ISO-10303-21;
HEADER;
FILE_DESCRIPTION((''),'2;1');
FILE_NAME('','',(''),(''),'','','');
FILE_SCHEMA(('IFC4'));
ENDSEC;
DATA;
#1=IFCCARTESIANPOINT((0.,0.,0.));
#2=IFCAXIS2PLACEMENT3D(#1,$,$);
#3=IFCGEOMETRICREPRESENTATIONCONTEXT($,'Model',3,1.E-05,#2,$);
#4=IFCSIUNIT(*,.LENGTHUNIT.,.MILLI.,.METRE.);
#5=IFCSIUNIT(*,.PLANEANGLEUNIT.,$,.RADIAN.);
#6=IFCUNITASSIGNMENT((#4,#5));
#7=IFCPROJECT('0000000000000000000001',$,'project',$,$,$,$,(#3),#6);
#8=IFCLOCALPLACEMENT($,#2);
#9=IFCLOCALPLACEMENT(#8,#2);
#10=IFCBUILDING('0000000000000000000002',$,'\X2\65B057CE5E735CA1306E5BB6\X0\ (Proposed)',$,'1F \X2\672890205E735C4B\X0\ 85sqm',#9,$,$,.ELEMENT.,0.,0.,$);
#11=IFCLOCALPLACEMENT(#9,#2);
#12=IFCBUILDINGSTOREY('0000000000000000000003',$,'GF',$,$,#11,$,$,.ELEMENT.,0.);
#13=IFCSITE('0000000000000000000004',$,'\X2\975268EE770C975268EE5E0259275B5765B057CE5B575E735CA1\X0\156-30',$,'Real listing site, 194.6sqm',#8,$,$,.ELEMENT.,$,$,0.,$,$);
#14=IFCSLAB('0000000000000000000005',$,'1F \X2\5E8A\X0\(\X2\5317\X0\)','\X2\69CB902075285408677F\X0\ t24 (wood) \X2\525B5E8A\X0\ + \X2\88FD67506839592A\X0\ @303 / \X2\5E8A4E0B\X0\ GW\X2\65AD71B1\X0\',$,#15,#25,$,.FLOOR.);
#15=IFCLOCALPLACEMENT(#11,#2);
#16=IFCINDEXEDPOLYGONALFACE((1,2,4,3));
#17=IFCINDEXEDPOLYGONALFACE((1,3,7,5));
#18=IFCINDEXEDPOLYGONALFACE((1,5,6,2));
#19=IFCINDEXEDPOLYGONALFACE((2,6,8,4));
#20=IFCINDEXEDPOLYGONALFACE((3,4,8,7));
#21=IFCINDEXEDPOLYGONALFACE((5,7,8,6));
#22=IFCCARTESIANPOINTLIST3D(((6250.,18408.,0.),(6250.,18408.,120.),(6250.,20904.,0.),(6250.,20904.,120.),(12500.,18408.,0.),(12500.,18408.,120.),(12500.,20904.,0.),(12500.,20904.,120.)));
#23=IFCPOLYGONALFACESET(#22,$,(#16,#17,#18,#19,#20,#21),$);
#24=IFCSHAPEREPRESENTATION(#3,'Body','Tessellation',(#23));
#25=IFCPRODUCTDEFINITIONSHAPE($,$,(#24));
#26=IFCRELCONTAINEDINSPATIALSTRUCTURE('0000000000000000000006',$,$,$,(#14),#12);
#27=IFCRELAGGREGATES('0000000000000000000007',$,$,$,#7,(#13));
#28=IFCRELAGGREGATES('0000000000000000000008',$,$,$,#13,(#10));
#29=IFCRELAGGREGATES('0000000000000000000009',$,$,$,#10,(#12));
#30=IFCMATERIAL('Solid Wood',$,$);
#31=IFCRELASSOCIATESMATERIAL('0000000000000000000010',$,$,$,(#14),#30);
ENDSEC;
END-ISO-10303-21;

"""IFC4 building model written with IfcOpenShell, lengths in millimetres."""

from ifc_helpers import new_model, si_unit, frame, frame_2d, origin, place, context, project, spatial, rectangle, extrude, material, element, save


model = new_model("IFC4")

# Units and contexts
model_context = context("Model", 3, precision=1e-05, world=origin())
ifc_project = project(units=[si_unit("LENGTHUNIT", "METRE", prefix="MILLI"), si_unit("PLANEANGLEUNIT", "RADIAN")], contexts=[model_context])

# Site, building, storey
site_placement = place(None, origin())
site = spatial("IfcSite", under=ifc_project, at=site_placement, Name="青森県青森市大字新城字平岡156-30", ObjectType="Real listing site, 194.6sqm", CompositionType="ELEMENT", RefElevation=0.0)
building_placement = place(site_placement, origin())
building = spatial("IfcBuilding", under=site, at=building_placement, Name="新城平岡の家 (Proposed)", ObjectType="1F 木造平屋 85sqm", CompositionType="ELEMENT", ElevationOfRefHeight=0.0, ElevationOfTerrain=0.0)
storey_placement = place(building_placement, origin())
storey = spatial("IfcBuildingStorey", under=building, at=storey_placement, Name="GF", CompositionType="ELEMENT", Elevation=0.0)

# Slab
ifc_material_1 = material(Name="Solid Wood")
slab_1_placement = place(storey_placement, frame((3125.0, 9204.0, 0.0)))
element("IfcSlab", 1, at=slab_1_placement, inside=storey, material=ifc_material_1, Name="1F 床(北)", Description="構造用合板 t24 (wood) 剛床 + 製材根太 @303 / 床下 GW断熱", PredefinedType="FLOOR", context=model_context, shape_type="SweptSolid", body=[
    extrude(rectangle(XDim=6250.0, YDim=2496.0, at=frame_2d((3125.0, 1248.0))), frame((3125.0, 9204.0, 0.0)), (0.0, 0.0, 1.0), 120.0),
])

save(model, "model.ifc")
